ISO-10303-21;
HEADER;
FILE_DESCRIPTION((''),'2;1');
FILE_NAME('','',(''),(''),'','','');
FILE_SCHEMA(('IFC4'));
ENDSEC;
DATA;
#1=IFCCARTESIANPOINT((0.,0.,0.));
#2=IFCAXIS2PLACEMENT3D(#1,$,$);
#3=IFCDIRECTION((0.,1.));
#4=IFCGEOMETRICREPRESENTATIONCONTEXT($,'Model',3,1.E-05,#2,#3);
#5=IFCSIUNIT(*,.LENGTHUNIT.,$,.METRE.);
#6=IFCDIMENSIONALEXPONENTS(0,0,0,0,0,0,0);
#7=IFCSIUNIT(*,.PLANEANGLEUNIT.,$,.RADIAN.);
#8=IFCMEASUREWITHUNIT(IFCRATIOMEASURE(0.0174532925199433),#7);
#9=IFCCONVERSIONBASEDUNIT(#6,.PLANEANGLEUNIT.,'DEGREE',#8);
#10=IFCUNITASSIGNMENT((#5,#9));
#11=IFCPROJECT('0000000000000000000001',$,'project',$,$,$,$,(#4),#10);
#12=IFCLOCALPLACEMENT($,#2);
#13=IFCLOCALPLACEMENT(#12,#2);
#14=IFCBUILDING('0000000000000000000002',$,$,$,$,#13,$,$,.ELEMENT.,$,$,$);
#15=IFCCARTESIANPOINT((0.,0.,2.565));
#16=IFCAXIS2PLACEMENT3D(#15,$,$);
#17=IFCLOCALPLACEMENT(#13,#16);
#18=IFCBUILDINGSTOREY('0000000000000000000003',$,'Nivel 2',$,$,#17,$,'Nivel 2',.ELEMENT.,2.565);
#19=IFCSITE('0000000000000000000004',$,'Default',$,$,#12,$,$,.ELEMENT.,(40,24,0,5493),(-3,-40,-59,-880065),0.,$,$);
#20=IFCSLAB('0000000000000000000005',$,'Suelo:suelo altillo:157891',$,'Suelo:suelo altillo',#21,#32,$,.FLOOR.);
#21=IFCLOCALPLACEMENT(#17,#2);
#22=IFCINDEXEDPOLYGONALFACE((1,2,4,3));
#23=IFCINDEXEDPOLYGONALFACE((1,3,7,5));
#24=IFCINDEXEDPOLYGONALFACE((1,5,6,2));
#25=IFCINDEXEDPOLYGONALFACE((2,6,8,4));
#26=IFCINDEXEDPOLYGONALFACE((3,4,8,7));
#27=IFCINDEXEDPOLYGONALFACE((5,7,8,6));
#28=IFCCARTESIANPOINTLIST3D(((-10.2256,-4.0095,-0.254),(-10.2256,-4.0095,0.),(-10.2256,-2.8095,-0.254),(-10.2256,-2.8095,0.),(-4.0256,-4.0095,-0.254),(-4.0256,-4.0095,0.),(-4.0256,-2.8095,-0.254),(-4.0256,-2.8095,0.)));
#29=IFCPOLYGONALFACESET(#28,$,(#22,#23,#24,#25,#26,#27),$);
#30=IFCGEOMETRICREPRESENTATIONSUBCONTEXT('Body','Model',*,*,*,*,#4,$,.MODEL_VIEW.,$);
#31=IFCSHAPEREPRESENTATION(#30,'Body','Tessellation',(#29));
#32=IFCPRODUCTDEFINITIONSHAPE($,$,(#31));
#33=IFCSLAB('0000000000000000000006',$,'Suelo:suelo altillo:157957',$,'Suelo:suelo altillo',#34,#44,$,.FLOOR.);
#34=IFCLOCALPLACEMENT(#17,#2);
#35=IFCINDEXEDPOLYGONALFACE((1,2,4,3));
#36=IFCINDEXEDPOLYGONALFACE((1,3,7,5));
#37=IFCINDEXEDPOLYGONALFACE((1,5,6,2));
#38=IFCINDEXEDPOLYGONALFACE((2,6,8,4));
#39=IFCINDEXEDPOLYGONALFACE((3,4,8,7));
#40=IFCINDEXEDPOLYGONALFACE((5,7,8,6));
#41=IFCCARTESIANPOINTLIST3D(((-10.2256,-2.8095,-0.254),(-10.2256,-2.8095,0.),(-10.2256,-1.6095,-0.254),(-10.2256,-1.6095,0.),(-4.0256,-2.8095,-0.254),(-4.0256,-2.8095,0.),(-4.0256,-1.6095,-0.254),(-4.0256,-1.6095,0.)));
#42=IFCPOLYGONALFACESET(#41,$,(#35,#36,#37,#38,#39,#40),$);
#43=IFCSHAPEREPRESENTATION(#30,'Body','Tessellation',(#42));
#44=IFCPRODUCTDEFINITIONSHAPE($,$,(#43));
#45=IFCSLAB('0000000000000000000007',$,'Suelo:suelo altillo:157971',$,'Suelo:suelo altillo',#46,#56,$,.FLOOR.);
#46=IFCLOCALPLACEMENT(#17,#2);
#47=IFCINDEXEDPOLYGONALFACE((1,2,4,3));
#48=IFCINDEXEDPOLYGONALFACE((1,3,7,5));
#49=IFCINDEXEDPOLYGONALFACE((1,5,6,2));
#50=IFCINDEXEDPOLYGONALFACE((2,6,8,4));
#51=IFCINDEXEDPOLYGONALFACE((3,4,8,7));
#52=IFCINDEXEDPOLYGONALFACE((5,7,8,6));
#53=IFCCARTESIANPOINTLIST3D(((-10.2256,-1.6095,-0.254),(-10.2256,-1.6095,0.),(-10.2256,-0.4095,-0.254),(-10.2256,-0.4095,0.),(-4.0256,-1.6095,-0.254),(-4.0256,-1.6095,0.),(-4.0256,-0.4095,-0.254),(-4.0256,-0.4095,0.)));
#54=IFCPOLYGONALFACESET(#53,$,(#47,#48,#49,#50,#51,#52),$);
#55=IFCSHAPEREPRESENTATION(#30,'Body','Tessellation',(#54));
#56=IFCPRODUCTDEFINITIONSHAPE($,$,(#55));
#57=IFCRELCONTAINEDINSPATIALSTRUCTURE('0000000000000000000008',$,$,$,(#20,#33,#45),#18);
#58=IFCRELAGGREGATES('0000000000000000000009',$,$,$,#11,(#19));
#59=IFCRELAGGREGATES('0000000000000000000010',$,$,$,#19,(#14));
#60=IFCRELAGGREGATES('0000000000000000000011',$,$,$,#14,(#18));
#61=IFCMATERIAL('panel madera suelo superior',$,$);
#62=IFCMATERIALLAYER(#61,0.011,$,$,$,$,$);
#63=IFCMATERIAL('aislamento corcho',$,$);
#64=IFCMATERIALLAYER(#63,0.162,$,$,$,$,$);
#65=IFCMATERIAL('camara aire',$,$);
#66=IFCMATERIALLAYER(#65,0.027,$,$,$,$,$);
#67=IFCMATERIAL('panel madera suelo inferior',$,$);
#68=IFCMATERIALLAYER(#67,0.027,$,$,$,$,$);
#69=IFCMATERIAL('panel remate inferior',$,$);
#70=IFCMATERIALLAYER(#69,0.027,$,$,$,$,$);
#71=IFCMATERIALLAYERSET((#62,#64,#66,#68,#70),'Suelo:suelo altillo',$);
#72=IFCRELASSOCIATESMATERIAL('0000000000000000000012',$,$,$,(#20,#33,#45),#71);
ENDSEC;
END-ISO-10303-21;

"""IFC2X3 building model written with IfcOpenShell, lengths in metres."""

from ifc_helpers import new_model, entity, si_unit, converted_unit, direction, frame, frame_2d, origin, origin_2d_with_axis, place, context, subcontext, project, spatial, rectangle, extrude, material, layer, layer_set, layer_usage, element, save


model = new_model("IFC2X3")

# Units and contexts
model_context = context("Model", 3, precision=1e-05, world=origin(), true_north=direction((0.0, 1.0)))
body_context = subcontext(model_context, "Body", "Model", "MODEL_VIEW")
ifc_project = project(units=[si_unit("LENGTHUNIT", "METRE"), converted_unit("PLANEANGLEUNIT", "DEGREE", entity("IfcRatioMeasure", 0.0174532925199433), si_unit("PLANEANGLEUNIT", "RADIAN"), dimensions=[0, 0, 0, 0, 0, 0, 0])], contexts=[model_context])

# Site, building, storey
site_placement = place(None, origin())
site = spatial("IfcSite", under=ifc_project, at=site_placement, Name="Default", CompositionType="ELEMENT", RefLatitude=(40, 24, 0, 5493), RefLongitude=(-3, -40, -59, -880065), RefElevation=0.0)
building_placement = place(site_placement, origin())
building = spatial("IfcBuilding", under=site, at=building_placement, CompositionType="ELEMENT")
storey_placement = place(building_placement, frame((0.0, 0.0, 2.565)))
storey = spatial("IfcBuildingStorey", under=building, at=storey_placement, Name="Nivel 2", LongName="Nivel 2", CompositionType="ELEMENT", Elevation=2.565)

# Slabs
ifc_material_1 = material(Name="panel madera suelo superior")
ifc_layer_1 = layer(ifc_material_1, 0.011)
ifc_material_2 = material(Name="aislamento corcho")
ifc_layer_2 = layer(ifc_material_2, 0.162)
ifc_material_3 = material(Name="camara aire")
ifc_layer_3 = layer(ifc_material_3, 0.027)
ifc_material_4 = material(Name="panel madera suelo inferior")
ifc_layer_4 = layer(ifc_material_4, 0.027)
ifc_material_5 = material(Name="panel remate inferior")
ifc_layer_5 = layer(ifc_material_5, 0.027)
ifc_layer_set = layer_set([ifc_layer_1, ifc_layer_2, ifc_layer_3, ifc_layer_4, ifc_layer_5], Name="Suelo:suelo altillo")
ifc_layer_usage_1 = layer_usage(ifc_layer_set, "AXIS3", "POSITIVE", 0.0)
slab_1_placement = place(storey_placement, origin())
element("IfcSlab", 1, at=slab_1_placement, inside=storey, material=ifc_layer_usage_1, Name="Suelo:suelo altillo:157891", ObjectType="Suelo:suelo altillo", PredefinedType="FLOOR", context=body_context, shape_type="SweptSolid", body=[
    extrude(rectangle(XDim=1.2, YDim=6.2, at=origin_2d_with_axis()), frame((-7.1256, -3.4095, 0.0), z_axis=(0.0, 0.0, -1.0), x_axis=(0.0, 1.0, 0.0)), (0.0, 0.0, 1.0), 0.254),
])
ifc_layer_usage_2 = layer_usage(ifc_layer_set, "AXIS3", "POSITIVE", 0.0)
slab_2_placement = place(storey_placement, origin())
element("IfcSlab", 2, at=slab_2_placement, inside=storey, material=ifc_layer_usage_2, Name="Suelo:suelo altillo:157957", ObjectType="Suelo:suelo altillo", PredefinedType="FLOOR", context=body_context, shape_type="SweptSolid", body=[
    extrude(rectangle(XDim=1.2, YDim=6.2, at=frame_2d((0.0, 0.0), x_axis=(1.0, 0.0))), frame((-7.1256, -2.2095, 0.0), z_axis=(0.0, 0.0, -1.0), x_axis=(0.0, 1.0, 0.0)), (0.0, 0.0, 1.0), 0.254),
])
ifc_layer_usage_3 = layer_usage(ifc_layer_set, "AXIS3", "POSITIVE", 0.0)
slab_3_placement = place(storey_placement, origin())
element("IfcSlab", 3, at=slab_3_placement, inside=storey, material=ifc_layer_usage_3, Name="Suelo:suelo altillo:157971", ObjectType="Suelo:suelo altillo", PredefinedType="FLOOR", context=body_context, shape_type="SweptSolid", body=[
    extrude(rectangle(XDim=1.2, YDim=6.2, at=frame_2d((0.0, 0.0), x_axis=(1.0, 0.0))), frame((-7.1256, -1.0095, 0.0), z_axis=(0.0, 0.0, -1.0), x_axis=(0.0, 1.0, 0.0)), (0.0, 0.0, 1.0), 0.254),
])

save(model, "model.ifc")
